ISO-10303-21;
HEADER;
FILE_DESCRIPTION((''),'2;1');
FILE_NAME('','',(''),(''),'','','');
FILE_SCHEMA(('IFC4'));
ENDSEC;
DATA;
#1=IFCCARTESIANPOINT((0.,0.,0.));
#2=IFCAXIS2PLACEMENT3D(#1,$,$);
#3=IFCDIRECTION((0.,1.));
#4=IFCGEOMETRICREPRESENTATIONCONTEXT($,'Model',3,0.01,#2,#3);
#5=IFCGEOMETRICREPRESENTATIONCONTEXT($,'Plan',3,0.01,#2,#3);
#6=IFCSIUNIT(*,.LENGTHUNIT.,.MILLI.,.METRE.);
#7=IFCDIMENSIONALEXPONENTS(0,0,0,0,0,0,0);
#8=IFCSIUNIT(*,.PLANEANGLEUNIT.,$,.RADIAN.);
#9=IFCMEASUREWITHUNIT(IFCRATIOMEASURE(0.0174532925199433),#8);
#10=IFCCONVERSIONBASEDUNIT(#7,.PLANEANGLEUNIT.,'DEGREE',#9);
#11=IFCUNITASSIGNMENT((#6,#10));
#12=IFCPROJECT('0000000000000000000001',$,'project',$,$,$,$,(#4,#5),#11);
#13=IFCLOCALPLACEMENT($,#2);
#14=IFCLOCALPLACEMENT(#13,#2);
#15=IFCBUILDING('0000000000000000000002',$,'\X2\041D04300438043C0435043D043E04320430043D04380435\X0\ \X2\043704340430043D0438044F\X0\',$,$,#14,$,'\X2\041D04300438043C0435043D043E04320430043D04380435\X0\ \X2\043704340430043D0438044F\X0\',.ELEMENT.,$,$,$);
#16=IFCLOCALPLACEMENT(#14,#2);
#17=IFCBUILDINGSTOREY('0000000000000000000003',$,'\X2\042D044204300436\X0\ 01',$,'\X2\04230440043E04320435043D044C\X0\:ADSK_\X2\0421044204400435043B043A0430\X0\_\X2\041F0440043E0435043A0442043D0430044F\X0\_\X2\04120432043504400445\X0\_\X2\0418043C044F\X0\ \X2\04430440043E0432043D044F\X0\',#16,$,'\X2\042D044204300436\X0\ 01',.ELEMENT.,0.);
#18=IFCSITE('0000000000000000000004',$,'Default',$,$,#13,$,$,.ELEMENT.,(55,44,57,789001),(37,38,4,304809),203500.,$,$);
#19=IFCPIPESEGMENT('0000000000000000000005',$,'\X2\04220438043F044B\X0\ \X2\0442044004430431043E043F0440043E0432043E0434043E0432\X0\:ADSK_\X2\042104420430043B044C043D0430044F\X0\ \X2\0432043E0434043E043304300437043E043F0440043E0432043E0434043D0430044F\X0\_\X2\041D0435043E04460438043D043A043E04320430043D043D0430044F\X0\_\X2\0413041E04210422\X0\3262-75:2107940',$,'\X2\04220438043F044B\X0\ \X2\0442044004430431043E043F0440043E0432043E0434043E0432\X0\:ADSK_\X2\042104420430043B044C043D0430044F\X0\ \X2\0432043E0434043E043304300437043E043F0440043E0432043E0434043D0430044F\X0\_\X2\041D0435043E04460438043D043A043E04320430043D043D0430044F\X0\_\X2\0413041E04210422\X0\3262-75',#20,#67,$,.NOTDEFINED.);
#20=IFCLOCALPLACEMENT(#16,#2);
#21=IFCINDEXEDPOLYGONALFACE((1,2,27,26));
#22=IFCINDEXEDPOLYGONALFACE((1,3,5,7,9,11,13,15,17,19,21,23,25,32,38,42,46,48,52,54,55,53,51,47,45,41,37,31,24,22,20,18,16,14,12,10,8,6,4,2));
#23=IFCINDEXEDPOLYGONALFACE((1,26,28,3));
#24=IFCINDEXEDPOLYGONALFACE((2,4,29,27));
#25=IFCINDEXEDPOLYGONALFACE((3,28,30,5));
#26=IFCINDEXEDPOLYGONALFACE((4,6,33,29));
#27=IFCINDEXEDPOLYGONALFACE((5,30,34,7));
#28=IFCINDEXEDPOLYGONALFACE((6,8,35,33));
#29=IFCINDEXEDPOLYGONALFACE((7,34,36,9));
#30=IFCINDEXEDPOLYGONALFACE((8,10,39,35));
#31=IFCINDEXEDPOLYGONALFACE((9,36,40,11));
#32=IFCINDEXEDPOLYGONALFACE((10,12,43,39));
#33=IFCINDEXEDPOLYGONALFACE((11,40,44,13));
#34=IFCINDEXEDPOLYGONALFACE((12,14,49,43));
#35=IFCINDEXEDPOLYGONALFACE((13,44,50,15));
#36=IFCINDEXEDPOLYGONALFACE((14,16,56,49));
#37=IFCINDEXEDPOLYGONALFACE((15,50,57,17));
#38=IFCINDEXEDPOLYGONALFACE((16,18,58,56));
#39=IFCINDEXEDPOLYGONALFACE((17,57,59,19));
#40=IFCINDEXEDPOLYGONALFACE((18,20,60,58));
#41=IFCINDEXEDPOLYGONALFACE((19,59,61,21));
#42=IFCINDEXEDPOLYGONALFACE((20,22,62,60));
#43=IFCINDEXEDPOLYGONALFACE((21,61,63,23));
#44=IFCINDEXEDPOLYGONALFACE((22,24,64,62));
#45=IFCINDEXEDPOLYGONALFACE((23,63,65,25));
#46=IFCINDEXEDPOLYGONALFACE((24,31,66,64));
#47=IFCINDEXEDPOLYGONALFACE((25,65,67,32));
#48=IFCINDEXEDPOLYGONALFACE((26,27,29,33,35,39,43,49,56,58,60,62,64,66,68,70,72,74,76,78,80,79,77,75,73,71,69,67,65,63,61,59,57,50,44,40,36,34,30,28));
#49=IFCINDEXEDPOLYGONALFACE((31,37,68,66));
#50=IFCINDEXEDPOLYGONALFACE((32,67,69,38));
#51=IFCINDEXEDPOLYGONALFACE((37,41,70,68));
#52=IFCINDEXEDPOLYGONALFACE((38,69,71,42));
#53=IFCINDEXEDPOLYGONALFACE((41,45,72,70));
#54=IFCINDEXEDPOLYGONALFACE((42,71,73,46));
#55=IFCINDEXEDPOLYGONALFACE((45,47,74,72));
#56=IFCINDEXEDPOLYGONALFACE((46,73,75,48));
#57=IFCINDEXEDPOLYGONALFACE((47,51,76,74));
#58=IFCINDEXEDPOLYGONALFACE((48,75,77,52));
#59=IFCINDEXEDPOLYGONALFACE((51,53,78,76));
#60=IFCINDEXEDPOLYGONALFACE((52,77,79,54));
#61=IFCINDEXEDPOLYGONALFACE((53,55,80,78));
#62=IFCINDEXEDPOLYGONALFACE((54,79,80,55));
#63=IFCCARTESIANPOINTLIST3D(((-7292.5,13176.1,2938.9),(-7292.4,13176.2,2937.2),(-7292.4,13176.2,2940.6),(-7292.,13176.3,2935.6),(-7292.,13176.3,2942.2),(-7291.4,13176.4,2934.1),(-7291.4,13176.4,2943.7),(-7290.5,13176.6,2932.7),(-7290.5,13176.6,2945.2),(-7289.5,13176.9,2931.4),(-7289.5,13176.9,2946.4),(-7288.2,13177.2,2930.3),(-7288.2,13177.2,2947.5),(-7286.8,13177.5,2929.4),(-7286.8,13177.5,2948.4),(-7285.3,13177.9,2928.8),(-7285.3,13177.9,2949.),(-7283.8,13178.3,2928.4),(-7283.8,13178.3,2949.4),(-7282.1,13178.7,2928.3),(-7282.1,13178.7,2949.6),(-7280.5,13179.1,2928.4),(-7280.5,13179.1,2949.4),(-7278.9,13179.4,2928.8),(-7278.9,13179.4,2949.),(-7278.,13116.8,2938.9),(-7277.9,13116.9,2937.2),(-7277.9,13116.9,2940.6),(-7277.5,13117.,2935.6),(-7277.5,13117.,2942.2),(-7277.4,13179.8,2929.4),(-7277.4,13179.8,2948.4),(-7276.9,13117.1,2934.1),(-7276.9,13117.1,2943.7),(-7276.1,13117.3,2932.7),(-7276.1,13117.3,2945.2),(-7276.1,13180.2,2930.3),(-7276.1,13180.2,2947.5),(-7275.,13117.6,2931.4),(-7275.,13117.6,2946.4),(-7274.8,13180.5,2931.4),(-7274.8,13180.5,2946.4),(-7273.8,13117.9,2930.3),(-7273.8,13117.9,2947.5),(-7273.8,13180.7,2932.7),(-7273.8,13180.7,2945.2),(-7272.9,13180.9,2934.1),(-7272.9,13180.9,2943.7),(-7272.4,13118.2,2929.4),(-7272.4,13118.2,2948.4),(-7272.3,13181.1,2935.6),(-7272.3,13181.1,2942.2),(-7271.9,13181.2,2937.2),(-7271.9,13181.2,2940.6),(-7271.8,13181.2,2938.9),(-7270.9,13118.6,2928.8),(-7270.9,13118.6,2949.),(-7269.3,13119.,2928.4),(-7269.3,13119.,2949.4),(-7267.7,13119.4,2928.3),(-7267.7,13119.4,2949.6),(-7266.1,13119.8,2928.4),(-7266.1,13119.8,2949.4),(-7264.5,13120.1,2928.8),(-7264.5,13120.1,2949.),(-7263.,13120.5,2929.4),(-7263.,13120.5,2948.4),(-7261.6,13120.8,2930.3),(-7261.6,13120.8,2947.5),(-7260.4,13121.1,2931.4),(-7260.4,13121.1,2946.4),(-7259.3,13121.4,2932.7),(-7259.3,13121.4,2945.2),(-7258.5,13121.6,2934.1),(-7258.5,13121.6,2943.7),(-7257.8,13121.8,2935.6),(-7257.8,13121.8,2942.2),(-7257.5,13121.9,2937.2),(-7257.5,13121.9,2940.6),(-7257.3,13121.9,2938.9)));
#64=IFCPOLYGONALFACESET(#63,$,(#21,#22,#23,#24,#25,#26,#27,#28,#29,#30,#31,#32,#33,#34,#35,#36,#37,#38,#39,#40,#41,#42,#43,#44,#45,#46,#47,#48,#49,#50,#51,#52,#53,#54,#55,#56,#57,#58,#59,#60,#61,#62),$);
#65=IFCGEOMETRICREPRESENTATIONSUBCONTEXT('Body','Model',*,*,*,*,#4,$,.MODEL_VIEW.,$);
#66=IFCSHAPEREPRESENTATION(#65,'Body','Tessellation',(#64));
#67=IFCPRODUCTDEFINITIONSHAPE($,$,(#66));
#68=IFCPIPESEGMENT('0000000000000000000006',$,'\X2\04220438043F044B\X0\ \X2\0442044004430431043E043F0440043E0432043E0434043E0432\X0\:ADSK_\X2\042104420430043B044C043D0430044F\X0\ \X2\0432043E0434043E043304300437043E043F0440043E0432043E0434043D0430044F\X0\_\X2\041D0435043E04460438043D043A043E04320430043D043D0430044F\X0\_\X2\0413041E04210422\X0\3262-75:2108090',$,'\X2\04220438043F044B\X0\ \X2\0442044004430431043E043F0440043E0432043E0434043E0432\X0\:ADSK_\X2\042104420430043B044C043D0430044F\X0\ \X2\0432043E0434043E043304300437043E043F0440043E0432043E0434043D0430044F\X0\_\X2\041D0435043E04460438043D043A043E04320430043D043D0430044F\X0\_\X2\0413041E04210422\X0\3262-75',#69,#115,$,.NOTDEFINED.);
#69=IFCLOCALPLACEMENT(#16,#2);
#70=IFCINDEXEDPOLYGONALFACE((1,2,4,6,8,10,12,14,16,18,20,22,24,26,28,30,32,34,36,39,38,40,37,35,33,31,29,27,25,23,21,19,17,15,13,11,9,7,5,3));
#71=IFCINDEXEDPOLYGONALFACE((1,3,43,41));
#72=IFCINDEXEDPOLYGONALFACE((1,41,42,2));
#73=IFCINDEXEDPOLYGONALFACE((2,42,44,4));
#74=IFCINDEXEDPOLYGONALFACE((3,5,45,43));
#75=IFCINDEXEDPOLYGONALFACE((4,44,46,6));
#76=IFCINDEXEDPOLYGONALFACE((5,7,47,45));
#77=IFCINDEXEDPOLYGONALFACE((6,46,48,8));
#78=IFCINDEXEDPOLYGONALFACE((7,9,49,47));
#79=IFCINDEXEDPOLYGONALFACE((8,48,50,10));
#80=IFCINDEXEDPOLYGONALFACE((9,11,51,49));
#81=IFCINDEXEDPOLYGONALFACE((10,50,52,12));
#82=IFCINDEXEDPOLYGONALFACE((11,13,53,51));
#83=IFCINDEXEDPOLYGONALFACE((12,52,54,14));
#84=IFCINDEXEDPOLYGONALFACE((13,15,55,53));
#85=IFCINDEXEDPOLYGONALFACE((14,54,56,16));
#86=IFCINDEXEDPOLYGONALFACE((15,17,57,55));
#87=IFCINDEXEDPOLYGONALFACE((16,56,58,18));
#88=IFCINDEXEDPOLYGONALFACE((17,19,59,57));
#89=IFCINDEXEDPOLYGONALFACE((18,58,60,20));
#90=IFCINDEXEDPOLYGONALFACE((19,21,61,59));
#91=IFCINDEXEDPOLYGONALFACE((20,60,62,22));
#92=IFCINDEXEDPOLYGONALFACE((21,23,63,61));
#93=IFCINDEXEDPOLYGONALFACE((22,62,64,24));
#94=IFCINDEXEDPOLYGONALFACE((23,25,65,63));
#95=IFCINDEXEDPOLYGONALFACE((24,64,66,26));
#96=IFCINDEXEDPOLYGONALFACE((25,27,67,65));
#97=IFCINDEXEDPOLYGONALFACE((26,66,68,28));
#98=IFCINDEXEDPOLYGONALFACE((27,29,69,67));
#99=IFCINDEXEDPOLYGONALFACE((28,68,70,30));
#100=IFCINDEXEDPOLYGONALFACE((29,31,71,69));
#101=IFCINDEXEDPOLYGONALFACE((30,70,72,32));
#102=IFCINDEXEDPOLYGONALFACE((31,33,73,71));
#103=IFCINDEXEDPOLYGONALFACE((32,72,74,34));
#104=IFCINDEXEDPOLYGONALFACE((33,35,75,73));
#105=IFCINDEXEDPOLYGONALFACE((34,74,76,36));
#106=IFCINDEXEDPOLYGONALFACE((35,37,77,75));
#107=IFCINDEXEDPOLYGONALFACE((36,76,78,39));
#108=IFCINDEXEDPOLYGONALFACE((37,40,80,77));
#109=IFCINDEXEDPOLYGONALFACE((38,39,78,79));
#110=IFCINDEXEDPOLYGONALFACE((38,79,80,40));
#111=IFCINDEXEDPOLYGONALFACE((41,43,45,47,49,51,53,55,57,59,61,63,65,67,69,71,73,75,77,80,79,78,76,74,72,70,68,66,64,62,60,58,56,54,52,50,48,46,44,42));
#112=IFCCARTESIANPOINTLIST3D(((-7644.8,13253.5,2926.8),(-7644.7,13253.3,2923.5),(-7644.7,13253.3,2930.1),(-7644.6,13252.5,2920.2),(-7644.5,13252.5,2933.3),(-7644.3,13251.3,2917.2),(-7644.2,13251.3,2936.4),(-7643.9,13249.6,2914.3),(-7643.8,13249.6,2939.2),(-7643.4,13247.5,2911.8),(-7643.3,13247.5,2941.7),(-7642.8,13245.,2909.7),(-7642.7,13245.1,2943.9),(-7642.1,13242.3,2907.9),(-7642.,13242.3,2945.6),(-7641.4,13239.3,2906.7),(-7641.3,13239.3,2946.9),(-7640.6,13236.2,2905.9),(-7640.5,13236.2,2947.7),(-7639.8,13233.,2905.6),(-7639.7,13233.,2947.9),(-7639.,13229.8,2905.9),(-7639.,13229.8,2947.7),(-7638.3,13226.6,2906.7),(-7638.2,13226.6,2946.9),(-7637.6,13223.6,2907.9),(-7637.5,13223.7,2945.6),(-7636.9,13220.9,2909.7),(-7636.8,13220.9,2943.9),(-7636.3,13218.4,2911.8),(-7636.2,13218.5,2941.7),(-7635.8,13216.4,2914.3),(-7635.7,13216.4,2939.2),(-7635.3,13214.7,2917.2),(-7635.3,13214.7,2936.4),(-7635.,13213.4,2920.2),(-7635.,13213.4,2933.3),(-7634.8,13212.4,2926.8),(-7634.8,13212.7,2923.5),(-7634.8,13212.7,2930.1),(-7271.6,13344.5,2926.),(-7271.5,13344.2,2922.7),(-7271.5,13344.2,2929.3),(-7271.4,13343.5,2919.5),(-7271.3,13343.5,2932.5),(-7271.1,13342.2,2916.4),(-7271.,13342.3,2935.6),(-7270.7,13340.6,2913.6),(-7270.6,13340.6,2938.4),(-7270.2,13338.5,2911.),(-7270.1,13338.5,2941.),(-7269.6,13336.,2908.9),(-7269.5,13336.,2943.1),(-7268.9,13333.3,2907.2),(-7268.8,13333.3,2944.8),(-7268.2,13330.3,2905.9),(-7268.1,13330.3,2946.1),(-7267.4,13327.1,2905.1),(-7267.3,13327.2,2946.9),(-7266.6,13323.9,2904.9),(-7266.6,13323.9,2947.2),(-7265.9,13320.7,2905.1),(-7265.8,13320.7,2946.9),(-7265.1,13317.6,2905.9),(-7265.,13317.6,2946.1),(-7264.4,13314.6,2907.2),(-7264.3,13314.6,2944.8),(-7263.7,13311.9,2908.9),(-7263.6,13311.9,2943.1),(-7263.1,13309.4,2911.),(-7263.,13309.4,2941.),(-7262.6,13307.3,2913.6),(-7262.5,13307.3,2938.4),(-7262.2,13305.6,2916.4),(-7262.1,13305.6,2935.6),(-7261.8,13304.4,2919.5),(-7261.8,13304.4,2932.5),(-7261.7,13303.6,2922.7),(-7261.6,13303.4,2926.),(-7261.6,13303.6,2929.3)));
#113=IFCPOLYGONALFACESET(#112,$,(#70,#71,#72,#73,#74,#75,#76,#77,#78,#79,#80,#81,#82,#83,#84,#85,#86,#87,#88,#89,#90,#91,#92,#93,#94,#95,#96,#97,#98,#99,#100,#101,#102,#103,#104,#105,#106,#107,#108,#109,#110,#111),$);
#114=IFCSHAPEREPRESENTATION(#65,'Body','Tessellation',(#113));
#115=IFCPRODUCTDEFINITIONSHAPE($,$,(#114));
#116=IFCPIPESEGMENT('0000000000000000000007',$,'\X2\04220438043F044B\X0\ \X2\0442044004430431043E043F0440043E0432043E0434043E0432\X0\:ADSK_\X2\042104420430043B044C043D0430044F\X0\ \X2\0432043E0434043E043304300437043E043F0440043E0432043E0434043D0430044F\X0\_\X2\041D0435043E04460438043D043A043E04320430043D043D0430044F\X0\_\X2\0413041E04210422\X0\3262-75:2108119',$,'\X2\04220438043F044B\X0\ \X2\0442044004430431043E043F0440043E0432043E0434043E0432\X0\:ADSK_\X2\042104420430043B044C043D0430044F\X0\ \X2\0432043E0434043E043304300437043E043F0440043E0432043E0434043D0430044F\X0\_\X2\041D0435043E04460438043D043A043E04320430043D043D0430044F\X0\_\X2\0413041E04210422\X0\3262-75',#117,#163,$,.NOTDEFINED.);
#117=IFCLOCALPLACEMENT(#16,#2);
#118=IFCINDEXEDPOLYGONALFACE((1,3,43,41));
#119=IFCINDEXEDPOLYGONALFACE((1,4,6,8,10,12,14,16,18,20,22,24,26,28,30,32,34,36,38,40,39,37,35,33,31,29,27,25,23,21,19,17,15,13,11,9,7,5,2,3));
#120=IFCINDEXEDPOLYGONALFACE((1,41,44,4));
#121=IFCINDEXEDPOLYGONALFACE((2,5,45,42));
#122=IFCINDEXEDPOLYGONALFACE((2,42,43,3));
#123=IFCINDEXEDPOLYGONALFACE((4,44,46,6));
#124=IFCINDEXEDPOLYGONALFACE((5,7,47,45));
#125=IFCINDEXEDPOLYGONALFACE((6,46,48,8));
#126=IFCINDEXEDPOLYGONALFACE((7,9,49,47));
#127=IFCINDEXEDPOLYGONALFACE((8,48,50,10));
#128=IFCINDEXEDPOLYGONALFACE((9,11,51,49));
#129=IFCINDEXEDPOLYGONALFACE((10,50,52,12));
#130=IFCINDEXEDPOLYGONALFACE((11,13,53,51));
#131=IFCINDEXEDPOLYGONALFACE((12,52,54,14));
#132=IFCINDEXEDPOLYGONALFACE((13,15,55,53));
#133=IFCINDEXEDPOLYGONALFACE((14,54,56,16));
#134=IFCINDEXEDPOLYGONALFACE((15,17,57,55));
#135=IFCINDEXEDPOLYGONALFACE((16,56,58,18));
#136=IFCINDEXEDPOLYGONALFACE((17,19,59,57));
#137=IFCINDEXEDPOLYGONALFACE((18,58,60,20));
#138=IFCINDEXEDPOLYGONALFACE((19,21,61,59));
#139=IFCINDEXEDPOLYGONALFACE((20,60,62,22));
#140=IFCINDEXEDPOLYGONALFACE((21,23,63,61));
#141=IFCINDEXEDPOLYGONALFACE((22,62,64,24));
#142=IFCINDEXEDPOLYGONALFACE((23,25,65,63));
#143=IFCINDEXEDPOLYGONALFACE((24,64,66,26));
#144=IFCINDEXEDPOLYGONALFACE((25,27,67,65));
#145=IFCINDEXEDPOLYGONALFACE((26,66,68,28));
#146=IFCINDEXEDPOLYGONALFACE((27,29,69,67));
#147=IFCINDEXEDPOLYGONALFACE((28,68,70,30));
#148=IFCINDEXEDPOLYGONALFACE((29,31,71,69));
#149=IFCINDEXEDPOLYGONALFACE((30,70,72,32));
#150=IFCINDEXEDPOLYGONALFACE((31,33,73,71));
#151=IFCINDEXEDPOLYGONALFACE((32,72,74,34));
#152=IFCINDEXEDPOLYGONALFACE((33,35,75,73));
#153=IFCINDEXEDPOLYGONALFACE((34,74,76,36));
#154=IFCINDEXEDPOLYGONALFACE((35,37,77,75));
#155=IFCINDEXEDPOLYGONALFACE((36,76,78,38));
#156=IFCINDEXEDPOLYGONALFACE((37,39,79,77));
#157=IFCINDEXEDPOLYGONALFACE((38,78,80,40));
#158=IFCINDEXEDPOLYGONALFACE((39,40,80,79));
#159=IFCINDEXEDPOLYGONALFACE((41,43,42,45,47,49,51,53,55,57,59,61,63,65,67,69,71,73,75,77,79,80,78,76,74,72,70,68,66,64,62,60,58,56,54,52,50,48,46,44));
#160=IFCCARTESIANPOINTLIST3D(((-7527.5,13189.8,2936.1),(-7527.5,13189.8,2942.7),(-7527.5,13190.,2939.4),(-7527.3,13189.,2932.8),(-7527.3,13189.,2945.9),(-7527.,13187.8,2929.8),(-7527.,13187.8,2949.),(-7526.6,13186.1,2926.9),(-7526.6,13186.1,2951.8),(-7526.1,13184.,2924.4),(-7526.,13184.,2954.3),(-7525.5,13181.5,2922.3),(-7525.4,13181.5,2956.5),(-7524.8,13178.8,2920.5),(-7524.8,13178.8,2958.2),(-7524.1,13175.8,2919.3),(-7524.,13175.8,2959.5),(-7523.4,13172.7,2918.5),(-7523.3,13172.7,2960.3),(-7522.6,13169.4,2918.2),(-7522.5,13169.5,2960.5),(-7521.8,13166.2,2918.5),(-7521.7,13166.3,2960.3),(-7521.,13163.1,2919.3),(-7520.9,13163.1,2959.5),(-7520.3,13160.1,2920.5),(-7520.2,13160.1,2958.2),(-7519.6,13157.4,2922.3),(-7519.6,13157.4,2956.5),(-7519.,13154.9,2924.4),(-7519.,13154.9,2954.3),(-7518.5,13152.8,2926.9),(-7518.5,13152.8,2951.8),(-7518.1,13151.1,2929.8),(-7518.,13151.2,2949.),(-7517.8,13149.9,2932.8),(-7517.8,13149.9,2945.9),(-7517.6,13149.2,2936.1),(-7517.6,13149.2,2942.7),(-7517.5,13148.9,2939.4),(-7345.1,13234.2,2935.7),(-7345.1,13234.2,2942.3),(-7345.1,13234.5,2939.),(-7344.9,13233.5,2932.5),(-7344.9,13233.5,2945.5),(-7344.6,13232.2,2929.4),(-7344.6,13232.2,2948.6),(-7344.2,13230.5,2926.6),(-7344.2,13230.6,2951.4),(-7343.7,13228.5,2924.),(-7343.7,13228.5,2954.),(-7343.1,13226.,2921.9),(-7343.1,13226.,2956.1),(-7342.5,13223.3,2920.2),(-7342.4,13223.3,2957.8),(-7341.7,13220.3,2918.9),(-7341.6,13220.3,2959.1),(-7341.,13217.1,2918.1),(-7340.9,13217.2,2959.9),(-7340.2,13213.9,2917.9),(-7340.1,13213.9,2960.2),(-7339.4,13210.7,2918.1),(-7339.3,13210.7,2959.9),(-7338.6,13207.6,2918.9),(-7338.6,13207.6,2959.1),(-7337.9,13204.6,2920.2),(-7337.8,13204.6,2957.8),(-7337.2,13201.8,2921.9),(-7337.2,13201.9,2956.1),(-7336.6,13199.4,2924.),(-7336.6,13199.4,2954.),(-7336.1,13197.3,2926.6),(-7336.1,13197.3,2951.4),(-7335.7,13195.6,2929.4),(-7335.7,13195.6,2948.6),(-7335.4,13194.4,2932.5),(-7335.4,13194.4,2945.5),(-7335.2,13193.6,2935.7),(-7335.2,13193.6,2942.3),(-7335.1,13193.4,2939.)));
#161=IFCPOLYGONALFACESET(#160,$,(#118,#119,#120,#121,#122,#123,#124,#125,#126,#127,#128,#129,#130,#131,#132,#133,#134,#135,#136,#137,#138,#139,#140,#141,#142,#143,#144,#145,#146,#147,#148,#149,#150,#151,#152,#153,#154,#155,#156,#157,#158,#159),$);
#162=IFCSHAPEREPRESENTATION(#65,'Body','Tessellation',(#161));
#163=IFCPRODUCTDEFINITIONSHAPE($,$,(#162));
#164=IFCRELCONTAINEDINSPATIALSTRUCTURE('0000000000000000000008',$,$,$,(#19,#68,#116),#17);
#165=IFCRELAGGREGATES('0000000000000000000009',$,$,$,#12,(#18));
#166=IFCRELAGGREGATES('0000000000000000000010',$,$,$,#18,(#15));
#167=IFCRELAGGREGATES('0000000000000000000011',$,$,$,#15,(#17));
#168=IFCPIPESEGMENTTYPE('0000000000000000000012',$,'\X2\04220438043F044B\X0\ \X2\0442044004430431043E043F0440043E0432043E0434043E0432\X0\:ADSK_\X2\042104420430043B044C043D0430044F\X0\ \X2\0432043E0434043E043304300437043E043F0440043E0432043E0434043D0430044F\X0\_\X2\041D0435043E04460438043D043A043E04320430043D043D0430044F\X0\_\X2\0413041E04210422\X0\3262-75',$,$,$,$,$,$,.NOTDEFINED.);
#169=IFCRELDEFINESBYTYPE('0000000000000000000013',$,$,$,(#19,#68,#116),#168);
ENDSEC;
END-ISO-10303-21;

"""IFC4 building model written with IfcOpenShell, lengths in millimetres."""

from ifc_helpers import new_model, entity, si_unit, converted_unit, direction, frame, origin, place, context, subcontext, project, spatial, indexed_curve, outline, extrude, type_object, element, save


model = new_model("IFC4")

# Units and contexts
model_context = context("Model", 3, precision=0.01, world=origin(), true_north=direction((0.0, 1.0)))
plan_context = context("Plan", 3, precision=0.01, world=origin(), true_north=direction((0.0, 1.0)))
body_context = subcontext(model_context, "Body", "Model", "MODEL_VIEW")
ifc_project = project(units=[si_unit("LENGTHUNIT", "METRE", prefix="MILLI"), converted_unit("PLANEANGLEUNIT", "DEGREE", entity("IfcRatioMeasure", 0.0174532925199433), si_unit("PLANEANGLEUNIT", "RADIAN"), dimensions=[0, 0, 0, 0, 0, 0, 0])], contexts=[model_context, plan_context])

# Site, building, storey
site_placement = place(None, origin())
site = spatial("IfcSite", under=ifc_project, at=site_placement, Name="Default", CompositionType="ELEMENT", RefLatitude=(55, 44, 57, 789001), RefLongitude=(37, 38, 4, 304809), RefElevation=203500.0)
building_placement = place(site_placement, origin())
building = spatial("IfcBuilding", under=site, at=building_placement, Name="Наименование здания", LongName="Наименование здания", CompositionType="ELEMENT")
storey_placement = place(building_placement, origin())
storey = spatial("IfcBuildingStorey", under=building, at=storey_placement, Name="Этаж 01", ObjectType="Уровень:ADSK_Стрелка_Проектная_Вверх_Имя уровня", LongName="Этаж 01", CompositionType="ELEMENT", Elevation=0.0)

# Pipe segments
pipe_segment_type = type_object("IfcPipeSegmentType", Name="Типы трубопроводов:ADSK_Стальная водогазопроводная_Неоцинкованная_ГОСТ3262-75", PredefinedType="NOTDEFINED")
placement = place(storey_placement, origin())
element("IfcPipeSegment", 1, at=placement, inside=storey, type_object=pipe_segment_type, Name="Типы трубопроводов:ADSK_Стальная водогазопроводная_Неоцинкованная_ГОСТ3262-75:2107940", ObjectType="Типы трубопроводов:ADSK_Стальная водогазопроводная_Неоцинкованная_ГОСТ3262-75", PredefinedType="NOTDEFINED", context=body_context, shape_type="SweptSolid", body=[
    extrude(outline(indexed_curve([(10.6, 0.0), (10.5, 1.7), (10.1, 3.3), (9.5, 4.8), (8.6, 6.3), (7.5, 7.5), (6.3, 8.6), (4.8, 9.5), (3.3, 10.1), (1.7, 10.5), (0.0, 10.6), (-1.7, 10.5), (-3.3, 10.1), (-4.8, 9.5), (-6.3, 8.6), (-7.5, 7.5), (-8.6, 6.3), (-9.5, 4.8), (-10.1, 3.3), (-10.5, 1.7), (-10.6, 0.0), (-10.5, -1.7), (-10.1, -3.3), (-9.5, -4.8), (-8.6, -6.3), (-7.5, -7.5), (-6.3, -8.6), (-4.8, -9.5), (-3.3, -10.1), (-1.7, -10.5), (0.0, -10.6), (1.7, -10.5), (3.3, -10.1), (4.8, -9.5), (6.3, -8.6), (7.5, -7.5), (8.6, -6.3), (9.5, -4.8), (10.1, -3.3), (10.5, -1.7), (10.6, 0.0)], self_intersect=False)), frame((-7282.1, 13178.7, 2938.9), z_axis=(0.236826, -0.971552, 0.0), x_axis=(-0.971552, -0.236826, 0.0)), (0.0, 0.0, 1.0), 61.0),
])
element("IfcPipeSegment", 2, at=placement, inside=storey, type_object=pipe_segment_type, Name="Типы трубопроводов:ADSK_Стальная водогазопроводная_Неоцинкованная_ГОСТ3262-75:2108090", ObjectType="Типы трубопроводов:ADSK_Стальная водогазопроводная_Неоцинкованная_ГОСТ3262-75", PredefinedType="NOTDEFINED", context=body_context, shape_type="SweptSolid", body=[
    extrude(outline(indexed_curve([(21.2, 0.0), (20.9, 3.3), (20.1, 6.5), (18.8, 9.6), (17.1, 12.4), (15.0, 15.0), (12.4, 17.1), (9.6, 18.8), (6.5, 20.1), (3.3, 20.9), (0.0, 21.2), (-3.3, 20.9), (-6.5, 20.1), (-9.6, 18.8), (-12.4, 17.1), (-15.0, 15.0), (-17.1, 12.4), (-18.8, 9.6), (-20.1, 6.5), (-20.9, 3.3), (-21.2, 0.0), (-20.9, -3.3), (-20.1, -6.5), (-18.8, -9.6), (-17.1, -12.4), (-15.0, -15.0), (-12.4, -17.1), (-9.6, -18.8), (-6.5, -20.1), (-3.3, -20.9), (0.0, -21.2), (3.3, -20.9), (6.5, -20.1), (9.6, -18.8), (12.4, -17.1), (15.0, -15.0), (17.1, -12.4), (18.8, -9.6), (20.1, -6.5), (20.9, -3.3), (21.2, 0.0)], self_intersect=False)), frame((-7639.8, 13233.0, 2926.8), z_axis=(0.971556, 0.2368, -0.002), x_axis=(0.2368, -0.971558, 0.0)), (0.0, 0.0, 1.0), 384.1),
])
element("IfcPipeSegment", 3, at=placement, inside=storey, type_object=pipe_segment_type, Name="Типы трубопроводов:ADSK_Стальная водогазопроводная_Неоцинкованная_ГОСТ3262-75:2108119", ObjectType="Типы трубопроводов:ADSK_Стальная водогазопроводная_Неоцинкованная_ГОСТ3262-75", PredefinedType="NOTDEFINED", context=body_context, shape_type="SweptSolid", body=[
    extrude(outline(indexed_curve([(21.2, 0.0), (20.9, 3.3), (20.1, 6.5), (18.8, 9.6), (17.1, 12.4), (15.0, 15.0), (12.4, 17.1), (9.6, 18.8), (6.5, 20.1), (3.3, 20.9), (0.0, 21.2), (-3.3, 20.9), (-6.5, 20.1), (-9.6, 18.8), (-12.4, 17.1), (-15.0, 15.0), (-17.1, 12.4), (-18.8, 9.6), (-20.1, 6.5), (-20.9, 3.3), (-21.2, 0.0), (-20.9, -3.3), (-20.1, -6.5), (-18.8, -9.6), (-17.1, -12.4), (-15.0, -15.0), (-12.4, -17.1), (-9.6, -18.8), (-6.5, -20.1), (-3.3, -20.9), (0.0, -21.1), (3.3, -20.9), (6.5, -20.1), (9.6, -18.8), (12.4, -17.1), (15.0, -15.0), (17.1, -12.4), (18.8, -9.6), (20.1, -6.5), (20.9, -3.3), (21.2, 0.0)], self_intersect=False)), frame((-7522.5, 13169.5, 2939.4), z_axis=(0.971536, 0.236883, -0.002), x_axis=(0.236883, -0.971538, 0.0)), (0.0, 0.0, 1.0), 187.7),
])

save(model, "model.ifc")
